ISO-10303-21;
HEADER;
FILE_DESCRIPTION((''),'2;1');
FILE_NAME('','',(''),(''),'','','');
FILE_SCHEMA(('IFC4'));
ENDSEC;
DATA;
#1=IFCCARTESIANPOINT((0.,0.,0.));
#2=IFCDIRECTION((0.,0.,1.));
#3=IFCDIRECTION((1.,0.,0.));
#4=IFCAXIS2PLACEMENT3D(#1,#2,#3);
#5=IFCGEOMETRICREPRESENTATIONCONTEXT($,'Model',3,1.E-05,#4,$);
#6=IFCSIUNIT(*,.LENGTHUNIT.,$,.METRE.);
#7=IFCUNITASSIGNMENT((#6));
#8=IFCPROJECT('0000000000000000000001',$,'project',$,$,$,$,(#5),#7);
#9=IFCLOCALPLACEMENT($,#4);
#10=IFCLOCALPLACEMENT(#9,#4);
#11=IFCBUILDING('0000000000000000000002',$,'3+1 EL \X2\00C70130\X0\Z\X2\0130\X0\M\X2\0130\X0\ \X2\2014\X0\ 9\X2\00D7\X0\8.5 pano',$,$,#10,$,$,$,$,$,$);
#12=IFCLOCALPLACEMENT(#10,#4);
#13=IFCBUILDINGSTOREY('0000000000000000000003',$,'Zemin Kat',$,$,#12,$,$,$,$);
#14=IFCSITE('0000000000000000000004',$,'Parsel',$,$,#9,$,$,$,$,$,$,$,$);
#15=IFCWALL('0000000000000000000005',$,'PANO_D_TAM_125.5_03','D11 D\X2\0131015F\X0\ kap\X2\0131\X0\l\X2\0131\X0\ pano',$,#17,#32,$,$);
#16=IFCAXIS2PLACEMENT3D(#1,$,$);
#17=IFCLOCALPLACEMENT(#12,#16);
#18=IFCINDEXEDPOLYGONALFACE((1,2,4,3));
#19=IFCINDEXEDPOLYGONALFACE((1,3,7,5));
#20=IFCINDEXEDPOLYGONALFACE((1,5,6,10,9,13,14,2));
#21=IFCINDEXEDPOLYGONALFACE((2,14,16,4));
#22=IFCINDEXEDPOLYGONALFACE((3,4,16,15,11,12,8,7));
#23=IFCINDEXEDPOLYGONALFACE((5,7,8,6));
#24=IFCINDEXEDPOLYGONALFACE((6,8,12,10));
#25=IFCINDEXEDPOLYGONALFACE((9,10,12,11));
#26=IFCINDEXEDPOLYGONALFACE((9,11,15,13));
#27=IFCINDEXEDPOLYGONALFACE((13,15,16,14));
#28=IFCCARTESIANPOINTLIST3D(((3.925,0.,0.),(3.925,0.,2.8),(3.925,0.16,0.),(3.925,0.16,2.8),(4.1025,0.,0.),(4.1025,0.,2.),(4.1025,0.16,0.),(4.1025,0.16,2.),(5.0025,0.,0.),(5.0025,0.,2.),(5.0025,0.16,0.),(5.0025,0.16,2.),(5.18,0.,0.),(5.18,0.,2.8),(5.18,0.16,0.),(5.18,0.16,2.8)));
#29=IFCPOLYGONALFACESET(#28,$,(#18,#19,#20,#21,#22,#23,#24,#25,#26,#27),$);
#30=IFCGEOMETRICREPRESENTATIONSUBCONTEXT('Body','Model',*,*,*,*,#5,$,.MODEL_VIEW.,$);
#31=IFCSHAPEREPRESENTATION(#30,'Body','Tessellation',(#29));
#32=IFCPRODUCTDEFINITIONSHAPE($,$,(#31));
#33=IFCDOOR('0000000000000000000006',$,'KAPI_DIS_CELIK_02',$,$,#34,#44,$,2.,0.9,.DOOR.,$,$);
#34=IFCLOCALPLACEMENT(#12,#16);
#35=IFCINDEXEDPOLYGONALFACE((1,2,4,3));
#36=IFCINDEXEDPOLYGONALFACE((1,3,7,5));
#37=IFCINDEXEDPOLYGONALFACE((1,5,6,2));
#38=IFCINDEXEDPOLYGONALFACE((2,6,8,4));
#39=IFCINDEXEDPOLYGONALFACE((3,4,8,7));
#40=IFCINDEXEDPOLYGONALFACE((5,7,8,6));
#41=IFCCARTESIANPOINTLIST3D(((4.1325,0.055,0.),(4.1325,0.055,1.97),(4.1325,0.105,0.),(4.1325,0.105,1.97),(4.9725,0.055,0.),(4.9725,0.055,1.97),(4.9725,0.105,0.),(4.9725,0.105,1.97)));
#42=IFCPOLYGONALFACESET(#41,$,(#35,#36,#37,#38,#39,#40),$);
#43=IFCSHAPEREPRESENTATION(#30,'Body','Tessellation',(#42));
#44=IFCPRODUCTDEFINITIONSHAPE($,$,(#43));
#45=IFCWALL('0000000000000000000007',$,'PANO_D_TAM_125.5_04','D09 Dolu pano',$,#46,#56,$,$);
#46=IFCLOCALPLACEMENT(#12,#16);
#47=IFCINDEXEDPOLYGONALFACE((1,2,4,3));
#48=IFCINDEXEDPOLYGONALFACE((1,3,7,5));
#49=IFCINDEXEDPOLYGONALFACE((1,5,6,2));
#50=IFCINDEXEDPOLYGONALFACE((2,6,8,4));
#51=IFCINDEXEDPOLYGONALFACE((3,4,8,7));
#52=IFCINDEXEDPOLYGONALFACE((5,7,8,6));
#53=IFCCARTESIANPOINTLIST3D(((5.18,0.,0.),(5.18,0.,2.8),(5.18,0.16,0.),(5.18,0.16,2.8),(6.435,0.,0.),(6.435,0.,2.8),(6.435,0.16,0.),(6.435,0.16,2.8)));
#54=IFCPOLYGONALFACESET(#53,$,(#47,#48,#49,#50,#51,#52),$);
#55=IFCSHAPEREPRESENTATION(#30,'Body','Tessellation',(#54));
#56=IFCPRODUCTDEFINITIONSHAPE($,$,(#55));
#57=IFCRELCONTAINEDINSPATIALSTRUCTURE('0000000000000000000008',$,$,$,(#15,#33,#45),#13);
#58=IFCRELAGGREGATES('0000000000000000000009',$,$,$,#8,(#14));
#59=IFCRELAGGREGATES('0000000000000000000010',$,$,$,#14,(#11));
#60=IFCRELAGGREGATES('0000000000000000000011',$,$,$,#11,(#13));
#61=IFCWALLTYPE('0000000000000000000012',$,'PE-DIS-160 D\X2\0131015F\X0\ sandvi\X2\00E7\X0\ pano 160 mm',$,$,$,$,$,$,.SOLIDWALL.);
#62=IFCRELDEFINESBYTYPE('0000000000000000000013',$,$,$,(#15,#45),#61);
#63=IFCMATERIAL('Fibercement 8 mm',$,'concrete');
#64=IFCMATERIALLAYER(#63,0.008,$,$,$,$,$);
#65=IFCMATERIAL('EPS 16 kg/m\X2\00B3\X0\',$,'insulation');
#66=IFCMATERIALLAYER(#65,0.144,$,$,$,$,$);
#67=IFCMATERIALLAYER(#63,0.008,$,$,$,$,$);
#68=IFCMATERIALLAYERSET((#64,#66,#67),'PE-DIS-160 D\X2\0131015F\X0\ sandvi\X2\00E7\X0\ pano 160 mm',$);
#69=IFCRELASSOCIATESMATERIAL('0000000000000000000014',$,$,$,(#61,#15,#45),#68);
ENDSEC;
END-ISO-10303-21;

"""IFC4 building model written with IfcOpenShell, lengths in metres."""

from ifc_helpers import new_model, si_unit, frame, origin_with_axes, place, context, subcontext, project, spatial, line, indexed_curve, outline, extrude, material, layer, layer_set, layer_usage, type_object, element, fill, save


model = new_model("IFC4")

# Units and contexts
model_context = context("Model", 3, precision=1e-05, world=origin_with_axes())
body_context = subcontext(model_context, "Body", "Model", "MODEL_VIEW")
ifc_project = project(units=[si_unit("LENGTHUNIT", "METRE")], contexts=[model_context])

# Site, building, storey
site_placement = place(None, origin_with_axes())
site = spatial("IfcSite", under=ifc_project, at=site_placement, Name="Parsel")
building_placement = place(site_placement, origin_with_axes())
building = spatial("IfcBuilding", under=site, at=building_placement, Name="3+1 EL ÇİZİMİ — 9×8.5 pano")
storey_placement = place(building_placement, origin_with_axes())
storey = spatial("IfcBuildingStorey", under=building, at=storey_placement, Name="Zemin Kat")

# Shared definitions
ifc_material_1 = material(Name="Fibercement 8 mm", Category="concrete")
ifc_layer_1 = layer(ifc_material_1, 0.008)
ifc_material_2 = material(Name="EPS 16 kg/m³", Category="insulation")
ifc_layer_2 = layer(ifc_material_2, 0.144)
ifc_layer_3 = layer(ifc_material_1, 0.008)
ifc_layer_set = layer_set([ifc_layer_1, ifc_layer_2, ifc_layer_3], Name="PE-DIS-160 Dış sandviç pano 160 mm")
wall_type = type_object("IfcWallType", Name="PE-DIS-160 Dış sandviç pano 160 mm", PredefinedType="SOLIDWALL", material=ifc_layer_set)

# Wall, opening, door
ifc_layer_usage_1 = layer_usage(ifc_layer_set, "AXIS2", "POSITIVE", 0.0)
wall_1_placement = place(storey_placement, frame((3.925, 0.0, 0.0), z_axis=(0.0, 0.0, 1.0), x_axis=(1.0, 0.0, 0.0)))
wall_1 = element("IfcWall", 1, at=wall_1_placement, inside=storey, type_object=wall_type, material=ifc_layer_usage_1, Name="PANO_D_TAM_125.5_03", Description="D11 Dış kapılı pano", context=body_context, shape_type="SweptSolid", body=[
    extrude(outline(indexed_curve([(0.0, 0.0), (1.255, 0.0), (1.255, 0.16), (0.0, 0.16)], segments=[line(1, 2, 3, 4, 1)])), origin_with_axes(), (0.0, 0.0, 1.0), 2.8),
])
opening_1_placement = place(wall_1_placement, origin_with_axes())
opening_1 = element("IfcOpeningElement", 2, at=opening_1_placement, cuts=wall_1, PredefinedType="OPENING", context=body_context, shape_type="SweptSolid", body=[
    extrude(outline(indexed_curve([(0.0, 0.0), (0.9, 0.0), (0.9, 0.2), (0.0, 0.2)], segments=[line(1, 2, 3, 4, 1)])), frame((0.1775, -0.02, 0.0), z_axis=(0.0, 0.0, 1.0), x_axis=(1.0, 0.0, 0.0)), (0.0, 0.0, 1.0), 2.0),
])
door_placement = place(storey_placement, frame((3.925, 0.0, 0.0), z_axis=(0.0, 0.0, 1.0), x_axis=(1.0, 0.0, 0.0)))
door = element("IfcDoor", 3, at=door_placement, inside=storey, Name="KAPI_DIS_CELIK_02", OverallHeight=2.0, OverallWidth=0.9, PredefinedType="DOOR", context=body_context, shape_type="SweptSolid", body=[
    extrude(outline(indexed_curve([(0.0, 0.0), (0.84, 0.0), (0.84, 0.05), (0.0, 0.05)], segments=[line(1, 2, 3, 4, 1)])), frame((0.2075, 0.055, 0.0), z_axis=(0.0, 0.0, 1.0), x_axis=(1.0, 0.0, 0.0)), (0.0, 0.0, 1.0), 1.97),
])
fill(opening_1, door)

# Wall
ifc_layer_usage_2 = layer_usage(ifc_layer_set, "AXIS2", "POSITIVE", 0.0)
wall_2_placement = place(storey_placement, frame((5.18, 0.0, 0.0), z_axis=(0.0, 0.0, 1.0), x_axis=(1.0, 0.0, 0.0)))
element("IfcWall", 4, at=wall_2_placement, inside=storey, type_object=wall_type, material=ifc_layer_usage_2, Name="PANO_D_TAM_125.5_04", Description="D09 Dolu pano", context=body_context, shape_type="SweptSolid", body=[
    extrude(outline(indexed_curve([(0.0, 0.0), (1.255, 0.0), (1.255, 0.16), (0.0, 0.16)], segments=[line(1, 2, 3, 4, 1)])), origin_with_axes(), (0.0, 0.0, 1.0), 2.8),
])

save(model, "model.ifc")
